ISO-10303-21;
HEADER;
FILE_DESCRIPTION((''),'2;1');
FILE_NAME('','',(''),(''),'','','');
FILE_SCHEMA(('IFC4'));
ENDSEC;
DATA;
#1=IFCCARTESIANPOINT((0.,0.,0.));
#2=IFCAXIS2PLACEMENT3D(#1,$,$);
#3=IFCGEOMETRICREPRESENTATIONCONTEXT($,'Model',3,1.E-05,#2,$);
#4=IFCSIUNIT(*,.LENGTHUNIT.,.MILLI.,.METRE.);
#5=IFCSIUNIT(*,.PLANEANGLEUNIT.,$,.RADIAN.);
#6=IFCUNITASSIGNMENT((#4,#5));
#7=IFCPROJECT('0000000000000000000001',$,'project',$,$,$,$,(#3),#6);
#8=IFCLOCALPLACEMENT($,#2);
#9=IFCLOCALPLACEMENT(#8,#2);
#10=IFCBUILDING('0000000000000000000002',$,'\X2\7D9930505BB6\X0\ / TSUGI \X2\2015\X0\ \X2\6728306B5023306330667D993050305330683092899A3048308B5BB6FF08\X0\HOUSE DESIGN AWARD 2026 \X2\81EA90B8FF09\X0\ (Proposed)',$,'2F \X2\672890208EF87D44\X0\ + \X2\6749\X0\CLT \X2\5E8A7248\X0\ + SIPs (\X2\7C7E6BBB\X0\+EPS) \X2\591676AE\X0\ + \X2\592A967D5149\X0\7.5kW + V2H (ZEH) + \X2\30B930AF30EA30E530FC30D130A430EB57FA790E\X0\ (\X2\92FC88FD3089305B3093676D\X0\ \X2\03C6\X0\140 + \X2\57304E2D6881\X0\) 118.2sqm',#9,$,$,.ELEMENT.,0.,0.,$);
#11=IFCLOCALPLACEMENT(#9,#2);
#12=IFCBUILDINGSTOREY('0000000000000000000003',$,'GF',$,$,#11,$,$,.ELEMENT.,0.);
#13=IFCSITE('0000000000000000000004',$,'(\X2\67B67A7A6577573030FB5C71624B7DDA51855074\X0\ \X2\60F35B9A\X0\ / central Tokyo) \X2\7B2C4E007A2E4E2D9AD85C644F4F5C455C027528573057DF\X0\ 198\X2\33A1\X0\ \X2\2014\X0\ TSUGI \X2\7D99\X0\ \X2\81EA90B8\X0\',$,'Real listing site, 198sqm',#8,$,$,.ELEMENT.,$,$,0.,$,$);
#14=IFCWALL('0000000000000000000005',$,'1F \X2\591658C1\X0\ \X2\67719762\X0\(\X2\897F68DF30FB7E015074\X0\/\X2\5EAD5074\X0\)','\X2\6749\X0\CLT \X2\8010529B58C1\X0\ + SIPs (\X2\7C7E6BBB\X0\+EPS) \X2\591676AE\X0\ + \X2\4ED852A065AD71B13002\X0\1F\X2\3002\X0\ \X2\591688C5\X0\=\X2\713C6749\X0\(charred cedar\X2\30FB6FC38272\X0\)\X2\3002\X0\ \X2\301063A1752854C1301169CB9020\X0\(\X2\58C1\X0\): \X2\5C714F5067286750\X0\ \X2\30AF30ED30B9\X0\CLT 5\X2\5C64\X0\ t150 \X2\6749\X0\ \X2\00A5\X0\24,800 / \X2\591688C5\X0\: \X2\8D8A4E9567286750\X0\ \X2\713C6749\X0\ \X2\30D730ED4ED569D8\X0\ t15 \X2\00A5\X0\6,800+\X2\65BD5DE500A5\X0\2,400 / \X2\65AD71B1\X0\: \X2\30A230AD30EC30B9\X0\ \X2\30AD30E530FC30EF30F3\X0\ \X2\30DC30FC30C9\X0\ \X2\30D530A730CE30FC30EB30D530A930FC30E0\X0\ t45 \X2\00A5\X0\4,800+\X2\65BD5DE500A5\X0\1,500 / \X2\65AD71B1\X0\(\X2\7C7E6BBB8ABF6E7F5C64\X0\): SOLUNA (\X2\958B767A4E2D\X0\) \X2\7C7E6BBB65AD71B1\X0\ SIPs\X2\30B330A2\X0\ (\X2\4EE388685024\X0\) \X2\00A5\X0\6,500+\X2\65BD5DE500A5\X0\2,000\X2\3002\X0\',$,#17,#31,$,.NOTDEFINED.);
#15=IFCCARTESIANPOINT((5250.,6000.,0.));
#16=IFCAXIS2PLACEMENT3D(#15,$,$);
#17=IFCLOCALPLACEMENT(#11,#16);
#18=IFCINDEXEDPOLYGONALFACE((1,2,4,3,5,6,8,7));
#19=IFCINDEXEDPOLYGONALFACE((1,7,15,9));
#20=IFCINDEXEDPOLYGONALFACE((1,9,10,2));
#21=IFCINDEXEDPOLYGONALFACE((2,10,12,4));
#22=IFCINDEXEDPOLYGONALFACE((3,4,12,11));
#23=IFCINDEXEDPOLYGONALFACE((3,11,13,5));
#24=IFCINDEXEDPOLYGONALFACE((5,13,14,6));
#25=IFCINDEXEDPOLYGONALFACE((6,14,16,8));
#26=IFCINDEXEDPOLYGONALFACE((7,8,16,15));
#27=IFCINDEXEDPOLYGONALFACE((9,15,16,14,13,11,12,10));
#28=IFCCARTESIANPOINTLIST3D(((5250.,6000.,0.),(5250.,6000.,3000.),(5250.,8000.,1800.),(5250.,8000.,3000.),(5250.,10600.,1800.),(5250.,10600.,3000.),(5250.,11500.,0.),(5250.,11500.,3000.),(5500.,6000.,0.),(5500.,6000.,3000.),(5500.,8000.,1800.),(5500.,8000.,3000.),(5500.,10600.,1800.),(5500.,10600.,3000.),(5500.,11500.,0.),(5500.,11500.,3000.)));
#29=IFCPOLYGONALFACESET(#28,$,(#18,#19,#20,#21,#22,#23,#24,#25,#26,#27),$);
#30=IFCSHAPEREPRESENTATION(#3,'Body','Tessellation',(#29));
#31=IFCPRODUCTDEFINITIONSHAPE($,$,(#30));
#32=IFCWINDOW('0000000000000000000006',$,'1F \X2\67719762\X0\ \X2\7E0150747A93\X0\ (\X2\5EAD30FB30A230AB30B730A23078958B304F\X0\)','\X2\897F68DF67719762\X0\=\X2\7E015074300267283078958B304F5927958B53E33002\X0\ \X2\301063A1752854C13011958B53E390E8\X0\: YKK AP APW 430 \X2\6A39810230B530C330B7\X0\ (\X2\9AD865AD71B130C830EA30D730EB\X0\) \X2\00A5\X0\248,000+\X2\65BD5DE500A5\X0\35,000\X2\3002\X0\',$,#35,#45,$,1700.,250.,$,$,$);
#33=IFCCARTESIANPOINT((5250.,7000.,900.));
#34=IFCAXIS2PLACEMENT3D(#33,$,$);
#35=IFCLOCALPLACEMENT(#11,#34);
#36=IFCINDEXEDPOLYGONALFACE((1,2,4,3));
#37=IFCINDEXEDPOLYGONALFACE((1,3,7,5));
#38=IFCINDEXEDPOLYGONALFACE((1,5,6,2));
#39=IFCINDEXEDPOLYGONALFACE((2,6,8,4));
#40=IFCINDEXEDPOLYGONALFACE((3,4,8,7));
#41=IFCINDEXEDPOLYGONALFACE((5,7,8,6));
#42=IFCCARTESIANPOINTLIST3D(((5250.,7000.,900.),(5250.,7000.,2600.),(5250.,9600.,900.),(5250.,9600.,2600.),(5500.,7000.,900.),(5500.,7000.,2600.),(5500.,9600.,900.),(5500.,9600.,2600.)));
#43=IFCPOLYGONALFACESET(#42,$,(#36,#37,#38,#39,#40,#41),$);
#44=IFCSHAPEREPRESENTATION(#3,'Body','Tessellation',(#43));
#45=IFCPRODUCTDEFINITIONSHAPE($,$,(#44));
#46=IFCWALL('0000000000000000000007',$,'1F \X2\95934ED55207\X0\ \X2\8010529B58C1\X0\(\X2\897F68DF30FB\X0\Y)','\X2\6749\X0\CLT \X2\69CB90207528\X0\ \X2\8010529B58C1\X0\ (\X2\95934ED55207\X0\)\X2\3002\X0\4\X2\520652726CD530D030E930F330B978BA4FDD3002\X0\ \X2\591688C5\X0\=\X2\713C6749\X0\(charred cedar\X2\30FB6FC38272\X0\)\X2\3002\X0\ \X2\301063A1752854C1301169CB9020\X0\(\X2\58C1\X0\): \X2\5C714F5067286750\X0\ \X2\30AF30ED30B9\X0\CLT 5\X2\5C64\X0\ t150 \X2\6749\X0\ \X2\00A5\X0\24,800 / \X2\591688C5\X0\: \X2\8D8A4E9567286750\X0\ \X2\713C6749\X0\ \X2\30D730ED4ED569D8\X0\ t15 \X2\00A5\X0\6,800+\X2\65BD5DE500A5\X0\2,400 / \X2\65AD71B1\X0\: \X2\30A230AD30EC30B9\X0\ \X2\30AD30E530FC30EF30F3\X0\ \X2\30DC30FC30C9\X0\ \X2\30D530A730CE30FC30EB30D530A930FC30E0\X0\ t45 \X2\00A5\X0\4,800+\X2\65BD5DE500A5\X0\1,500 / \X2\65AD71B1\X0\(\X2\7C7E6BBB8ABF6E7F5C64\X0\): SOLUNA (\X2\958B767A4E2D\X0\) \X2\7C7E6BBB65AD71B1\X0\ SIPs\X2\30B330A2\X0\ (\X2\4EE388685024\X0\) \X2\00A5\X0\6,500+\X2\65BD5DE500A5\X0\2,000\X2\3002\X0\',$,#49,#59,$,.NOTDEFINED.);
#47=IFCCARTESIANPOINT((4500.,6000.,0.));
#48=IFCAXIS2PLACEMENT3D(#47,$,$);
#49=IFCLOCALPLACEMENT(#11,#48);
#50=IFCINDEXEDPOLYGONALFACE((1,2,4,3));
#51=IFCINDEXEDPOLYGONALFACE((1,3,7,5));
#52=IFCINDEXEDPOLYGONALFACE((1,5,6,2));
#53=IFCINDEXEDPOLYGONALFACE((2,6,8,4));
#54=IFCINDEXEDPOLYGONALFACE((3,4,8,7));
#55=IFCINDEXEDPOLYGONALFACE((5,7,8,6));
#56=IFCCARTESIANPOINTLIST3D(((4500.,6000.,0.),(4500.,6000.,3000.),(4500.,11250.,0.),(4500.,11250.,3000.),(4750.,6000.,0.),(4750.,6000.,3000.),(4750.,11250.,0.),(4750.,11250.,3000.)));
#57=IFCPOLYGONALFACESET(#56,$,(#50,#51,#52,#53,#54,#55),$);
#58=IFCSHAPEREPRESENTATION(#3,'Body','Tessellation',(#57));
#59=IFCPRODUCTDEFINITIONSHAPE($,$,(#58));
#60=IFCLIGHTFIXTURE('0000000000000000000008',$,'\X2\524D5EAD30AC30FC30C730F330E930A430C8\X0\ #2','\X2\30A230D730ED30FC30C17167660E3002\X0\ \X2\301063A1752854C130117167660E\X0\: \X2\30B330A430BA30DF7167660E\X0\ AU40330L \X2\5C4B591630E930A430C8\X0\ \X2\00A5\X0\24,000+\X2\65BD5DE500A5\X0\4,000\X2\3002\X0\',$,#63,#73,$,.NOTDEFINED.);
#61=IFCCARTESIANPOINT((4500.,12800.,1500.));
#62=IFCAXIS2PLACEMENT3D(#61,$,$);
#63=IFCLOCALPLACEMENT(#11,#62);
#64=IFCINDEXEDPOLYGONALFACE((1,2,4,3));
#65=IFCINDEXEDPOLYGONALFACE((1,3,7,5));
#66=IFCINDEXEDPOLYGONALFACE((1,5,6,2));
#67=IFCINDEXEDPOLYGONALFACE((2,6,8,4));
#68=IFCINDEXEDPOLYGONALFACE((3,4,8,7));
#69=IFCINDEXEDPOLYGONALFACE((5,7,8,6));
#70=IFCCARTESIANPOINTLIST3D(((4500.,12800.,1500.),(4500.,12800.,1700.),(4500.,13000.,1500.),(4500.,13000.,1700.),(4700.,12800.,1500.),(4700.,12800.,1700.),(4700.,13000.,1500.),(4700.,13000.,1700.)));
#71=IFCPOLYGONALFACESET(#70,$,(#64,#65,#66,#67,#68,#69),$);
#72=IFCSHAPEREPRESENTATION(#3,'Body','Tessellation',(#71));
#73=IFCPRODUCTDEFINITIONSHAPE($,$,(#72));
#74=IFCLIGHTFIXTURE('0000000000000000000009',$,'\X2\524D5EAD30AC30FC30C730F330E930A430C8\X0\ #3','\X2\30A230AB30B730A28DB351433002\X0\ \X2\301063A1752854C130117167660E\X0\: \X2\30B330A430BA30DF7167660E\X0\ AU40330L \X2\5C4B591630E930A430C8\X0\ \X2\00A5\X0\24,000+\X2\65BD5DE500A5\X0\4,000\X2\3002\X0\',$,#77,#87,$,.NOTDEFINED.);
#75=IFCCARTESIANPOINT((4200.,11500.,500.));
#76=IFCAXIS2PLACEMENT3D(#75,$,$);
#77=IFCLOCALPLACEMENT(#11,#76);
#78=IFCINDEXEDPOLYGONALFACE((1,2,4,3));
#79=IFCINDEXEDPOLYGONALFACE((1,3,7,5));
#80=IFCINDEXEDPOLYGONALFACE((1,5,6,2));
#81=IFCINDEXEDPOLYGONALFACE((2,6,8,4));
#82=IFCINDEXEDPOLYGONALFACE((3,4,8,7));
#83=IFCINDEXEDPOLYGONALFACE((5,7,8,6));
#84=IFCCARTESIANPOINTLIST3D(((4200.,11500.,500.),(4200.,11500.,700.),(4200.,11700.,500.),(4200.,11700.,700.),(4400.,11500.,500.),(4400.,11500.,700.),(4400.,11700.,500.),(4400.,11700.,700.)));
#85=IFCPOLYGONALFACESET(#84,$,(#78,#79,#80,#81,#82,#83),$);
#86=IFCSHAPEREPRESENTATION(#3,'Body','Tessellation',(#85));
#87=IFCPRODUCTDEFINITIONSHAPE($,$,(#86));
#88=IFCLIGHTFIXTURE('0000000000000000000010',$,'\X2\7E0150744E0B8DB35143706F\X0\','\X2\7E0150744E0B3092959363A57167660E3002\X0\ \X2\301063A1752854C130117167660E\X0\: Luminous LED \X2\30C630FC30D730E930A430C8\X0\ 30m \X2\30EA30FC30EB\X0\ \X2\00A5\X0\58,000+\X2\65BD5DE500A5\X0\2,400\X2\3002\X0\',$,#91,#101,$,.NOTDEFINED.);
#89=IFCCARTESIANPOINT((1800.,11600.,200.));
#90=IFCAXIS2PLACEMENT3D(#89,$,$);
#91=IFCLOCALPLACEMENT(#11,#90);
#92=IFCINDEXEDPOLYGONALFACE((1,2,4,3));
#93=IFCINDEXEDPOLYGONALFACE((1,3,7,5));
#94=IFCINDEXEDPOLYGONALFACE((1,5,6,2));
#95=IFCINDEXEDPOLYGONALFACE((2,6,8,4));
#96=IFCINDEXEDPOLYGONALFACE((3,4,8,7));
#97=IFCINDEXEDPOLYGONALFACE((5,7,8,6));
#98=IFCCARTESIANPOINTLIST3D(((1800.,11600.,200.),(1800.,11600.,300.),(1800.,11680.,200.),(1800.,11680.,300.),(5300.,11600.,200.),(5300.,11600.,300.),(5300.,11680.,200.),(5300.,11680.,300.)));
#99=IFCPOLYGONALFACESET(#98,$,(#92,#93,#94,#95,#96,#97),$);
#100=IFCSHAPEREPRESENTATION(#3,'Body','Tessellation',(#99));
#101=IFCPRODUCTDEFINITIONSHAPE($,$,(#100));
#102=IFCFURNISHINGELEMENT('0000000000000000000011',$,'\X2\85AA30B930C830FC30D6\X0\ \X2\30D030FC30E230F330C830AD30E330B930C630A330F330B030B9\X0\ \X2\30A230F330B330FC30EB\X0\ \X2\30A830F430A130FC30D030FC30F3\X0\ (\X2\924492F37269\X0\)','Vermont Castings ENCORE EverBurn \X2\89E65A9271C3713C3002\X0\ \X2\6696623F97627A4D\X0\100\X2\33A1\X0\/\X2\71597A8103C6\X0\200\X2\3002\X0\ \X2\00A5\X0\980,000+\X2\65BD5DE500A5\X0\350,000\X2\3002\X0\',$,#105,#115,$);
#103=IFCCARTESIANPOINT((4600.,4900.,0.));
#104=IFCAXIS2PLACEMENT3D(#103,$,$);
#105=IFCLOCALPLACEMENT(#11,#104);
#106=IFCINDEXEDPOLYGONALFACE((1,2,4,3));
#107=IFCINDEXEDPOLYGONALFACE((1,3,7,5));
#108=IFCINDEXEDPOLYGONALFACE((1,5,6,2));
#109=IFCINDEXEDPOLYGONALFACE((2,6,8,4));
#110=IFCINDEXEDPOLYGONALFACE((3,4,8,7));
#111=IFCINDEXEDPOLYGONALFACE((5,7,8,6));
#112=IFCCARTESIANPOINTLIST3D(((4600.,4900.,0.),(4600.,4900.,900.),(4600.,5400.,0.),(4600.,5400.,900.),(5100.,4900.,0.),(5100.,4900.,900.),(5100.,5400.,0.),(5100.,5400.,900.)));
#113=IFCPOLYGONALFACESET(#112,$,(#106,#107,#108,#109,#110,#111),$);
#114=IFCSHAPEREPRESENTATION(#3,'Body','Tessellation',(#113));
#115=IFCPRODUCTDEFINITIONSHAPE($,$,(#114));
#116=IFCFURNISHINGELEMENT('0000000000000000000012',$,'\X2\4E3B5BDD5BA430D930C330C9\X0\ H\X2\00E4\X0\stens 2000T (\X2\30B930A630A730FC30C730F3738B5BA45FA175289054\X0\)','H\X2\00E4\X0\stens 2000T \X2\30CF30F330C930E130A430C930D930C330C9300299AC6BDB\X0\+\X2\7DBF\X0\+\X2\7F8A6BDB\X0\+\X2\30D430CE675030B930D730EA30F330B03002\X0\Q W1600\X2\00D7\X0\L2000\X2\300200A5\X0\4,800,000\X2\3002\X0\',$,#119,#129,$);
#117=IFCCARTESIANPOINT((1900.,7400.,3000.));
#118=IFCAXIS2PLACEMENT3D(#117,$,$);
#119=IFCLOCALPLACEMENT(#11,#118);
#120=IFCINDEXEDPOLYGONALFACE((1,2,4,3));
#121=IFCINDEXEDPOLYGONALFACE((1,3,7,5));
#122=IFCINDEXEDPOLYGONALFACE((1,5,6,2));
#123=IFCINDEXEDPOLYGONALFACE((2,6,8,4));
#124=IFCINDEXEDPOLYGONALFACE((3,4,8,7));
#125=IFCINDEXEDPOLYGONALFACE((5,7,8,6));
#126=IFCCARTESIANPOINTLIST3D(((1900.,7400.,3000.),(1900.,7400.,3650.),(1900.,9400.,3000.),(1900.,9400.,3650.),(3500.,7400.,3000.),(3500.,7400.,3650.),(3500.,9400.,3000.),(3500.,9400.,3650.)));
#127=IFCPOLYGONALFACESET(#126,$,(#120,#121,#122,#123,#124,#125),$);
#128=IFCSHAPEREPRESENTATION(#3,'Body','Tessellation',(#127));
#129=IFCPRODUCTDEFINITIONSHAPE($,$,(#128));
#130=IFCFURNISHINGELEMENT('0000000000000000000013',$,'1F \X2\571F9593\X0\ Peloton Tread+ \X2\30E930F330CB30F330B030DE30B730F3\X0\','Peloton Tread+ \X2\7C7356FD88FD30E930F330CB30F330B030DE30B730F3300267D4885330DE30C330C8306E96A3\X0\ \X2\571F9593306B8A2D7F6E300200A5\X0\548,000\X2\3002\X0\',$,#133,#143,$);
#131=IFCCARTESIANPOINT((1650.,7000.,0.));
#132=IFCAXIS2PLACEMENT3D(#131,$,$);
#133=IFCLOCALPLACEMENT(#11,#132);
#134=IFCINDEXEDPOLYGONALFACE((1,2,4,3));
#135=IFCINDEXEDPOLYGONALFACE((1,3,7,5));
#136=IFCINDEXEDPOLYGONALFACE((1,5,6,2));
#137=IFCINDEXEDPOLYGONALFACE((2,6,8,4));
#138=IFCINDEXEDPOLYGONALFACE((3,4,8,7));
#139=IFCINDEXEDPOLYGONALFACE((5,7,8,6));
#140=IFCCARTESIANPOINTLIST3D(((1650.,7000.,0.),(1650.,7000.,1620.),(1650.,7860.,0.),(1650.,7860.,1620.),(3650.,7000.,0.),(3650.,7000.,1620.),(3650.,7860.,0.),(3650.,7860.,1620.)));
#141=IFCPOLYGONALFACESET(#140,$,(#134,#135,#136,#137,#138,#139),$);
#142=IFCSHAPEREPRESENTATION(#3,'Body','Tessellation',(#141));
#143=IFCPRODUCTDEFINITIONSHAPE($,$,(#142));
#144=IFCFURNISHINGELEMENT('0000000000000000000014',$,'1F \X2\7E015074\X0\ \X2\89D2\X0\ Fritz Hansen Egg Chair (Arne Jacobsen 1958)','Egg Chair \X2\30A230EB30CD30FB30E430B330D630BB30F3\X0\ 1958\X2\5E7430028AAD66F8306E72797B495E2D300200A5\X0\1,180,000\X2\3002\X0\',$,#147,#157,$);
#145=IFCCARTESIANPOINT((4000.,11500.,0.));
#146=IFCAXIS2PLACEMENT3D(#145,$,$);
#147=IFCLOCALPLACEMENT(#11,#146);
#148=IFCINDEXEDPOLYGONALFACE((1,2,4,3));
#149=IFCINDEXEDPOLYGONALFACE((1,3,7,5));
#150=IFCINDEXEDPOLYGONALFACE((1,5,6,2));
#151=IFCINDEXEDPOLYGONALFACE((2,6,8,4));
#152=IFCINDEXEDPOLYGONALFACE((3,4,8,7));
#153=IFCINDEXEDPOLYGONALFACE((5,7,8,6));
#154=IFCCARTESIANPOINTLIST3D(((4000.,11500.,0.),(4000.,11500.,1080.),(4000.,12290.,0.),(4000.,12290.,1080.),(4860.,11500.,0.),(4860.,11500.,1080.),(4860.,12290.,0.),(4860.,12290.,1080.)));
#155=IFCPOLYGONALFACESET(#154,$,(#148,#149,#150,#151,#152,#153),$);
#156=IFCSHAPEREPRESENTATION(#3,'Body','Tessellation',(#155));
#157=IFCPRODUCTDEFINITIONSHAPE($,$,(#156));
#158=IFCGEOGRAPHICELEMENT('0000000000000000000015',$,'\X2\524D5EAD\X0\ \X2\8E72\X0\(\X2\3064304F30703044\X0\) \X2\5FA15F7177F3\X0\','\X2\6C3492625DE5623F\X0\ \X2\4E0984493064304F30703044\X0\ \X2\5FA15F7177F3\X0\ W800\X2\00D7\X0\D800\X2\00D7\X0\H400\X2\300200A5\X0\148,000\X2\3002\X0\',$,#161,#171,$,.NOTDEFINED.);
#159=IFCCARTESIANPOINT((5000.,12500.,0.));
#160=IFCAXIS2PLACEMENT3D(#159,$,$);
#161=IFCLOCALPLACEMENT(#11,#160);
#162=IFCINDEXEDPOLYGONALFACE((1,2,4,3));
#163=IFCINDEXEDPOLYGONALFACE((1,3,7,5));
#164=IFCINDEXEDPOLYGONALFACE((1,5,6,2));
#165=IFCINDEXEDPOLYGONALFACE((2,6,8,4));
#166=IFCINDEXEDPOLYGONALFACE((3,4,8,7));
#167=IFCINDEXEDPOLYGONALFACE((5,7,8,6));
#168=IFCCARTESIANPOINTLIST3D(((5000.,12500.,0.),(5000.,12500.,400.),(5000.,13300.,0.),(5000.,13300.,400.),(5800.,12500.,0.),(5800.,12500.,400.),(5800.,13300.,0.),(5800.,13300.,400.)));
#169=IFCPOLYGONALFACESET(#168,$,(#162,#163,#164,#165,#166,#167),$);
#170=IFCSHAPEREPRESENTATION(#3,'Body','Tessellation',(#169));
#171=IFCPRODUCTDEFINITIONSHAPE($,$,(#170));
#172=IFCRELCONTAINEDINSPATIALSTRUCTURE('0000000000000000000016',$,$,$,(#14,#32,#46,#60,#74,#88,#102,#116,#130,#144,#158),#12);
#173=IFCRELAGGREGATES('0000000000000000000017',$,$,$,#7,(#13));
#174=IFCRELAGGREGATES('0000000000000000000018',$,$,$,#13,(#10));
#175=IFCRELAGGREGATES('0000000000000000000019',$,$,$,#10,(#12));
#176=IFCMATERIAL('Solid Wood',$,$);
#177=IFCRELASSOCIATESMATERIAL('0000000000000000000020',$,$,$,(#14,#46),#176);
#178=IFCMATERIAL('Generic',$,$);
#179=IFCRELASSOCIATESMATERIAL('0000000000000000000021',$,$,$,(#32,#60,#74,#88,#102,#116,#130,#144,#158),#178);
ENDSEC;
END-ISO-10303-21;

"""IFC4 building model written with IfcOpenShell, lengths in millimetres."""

from ifc_helpers import new_model, si_unit, frame, frame_2d, origin, place, context, project, spatial, rectangle, extrude, material, element, fill, save


model = new_model("IFC4")

# Units and contexts
model_context = context("Model", 3, precision=1e-05, world=origin())
ifc_project = project(units=[si_unit("LENGTHUNIT", "METRE", prefix="MILLI"), si_unit("PLANEANGLEUNIT", "RADIAN")], contexts=[model_context])

# Site, building, storey
site_placement = place(None, origin())
site = spatial("IfcSite", under=ifc_project, at=site_placement, Name="(架空敷地・山手線内側 想定 / central Tokyo) 第一種中高層住居専用地域 198㎡ — TSUGI 継 自邸", ObjectType="Real listing site, 198sqm", CompositionType="ELEMENT", RefElevation=0.0)
building_placement = place(site_placement, origin())
building = spatial("IfcBuilding", under=site, at=building_placement, Name="継ぐ家 / TSUGI ― 木に倣って継ぐことを覚える家（HOUSE DESIGN AWARD 2026 自邸） (Proposed)", ObjectType="2F 木造軸組 + 杉CLT 床版 + SIPs (籾殻+EPS) 外皮 + 太陽光7.5kW + V2H (ZEH) + スクリューパイル基礎 (鋼製らせん杭 φ140 + 地中梁) 118.2sqm", CompositionType="ELEMENT", ElevationOfRefHeight=0.0, ElevationOfTerrain=0.0)
storey_placement = place(building_placement, origin())
storey = spatial("IfcBuildingStorey", under=building, at=storey_placement, Name="GF", CompositionType="ELEMENT", Elevation=0.0)

# Shared definitions
ifc_material_1 = material(Name="Generic")

# Wall, opening, window
ifc_material_2 = material(Name="Solid Wood")
wall_1_placement = place(storey_placement, frame((5250.0, 6000.0, 0.0)))
wall_1 = element("IfcWall", 1, at=wall_1_placement, inside=storey, material=ifc_material_2, Name="1F 外壁 東面(西棟・縁側/庭側)", Description="杉CLT 耐力壁 + SIPs (籾殻+EPS) 外皮 + 付加断熱。1F。 外装=焼杉(charred cedar・濃色)。 【採用品】構造(壁): 山佐木材 クロスCLT 5層 t150 杉 ¥24,800 / 外装: 越井木材 焼杉 プロ仕様 t15 ¥6,800+施工¥2,400 / 断熱: アキレス キューワン ボード フェノールフォーム t45 ¥4,800+施工¥1,500 / 断熱(籾殻調湿層): SOLUNA (開発中) 籾殻断熱 SIPsコア (代表値) ¥6,500+施工¥2,000。", PredefinedType="NOTDEFINED", context=model_context, shape_type="SweptSolid", body=[
    extrude(rectangle(XDim=250.0, YDim=5500.0, at=frame_2d((125.0, 2750.0))), frame((5250.0, 6000.0, 0.0)), (0.0, 0.0, 1.0), 3000.0),
])
opening_placement = place(storey_placement, frame((5250.0, 7000.0, 900.0)))
opening = element("IfcOpeningElement", 2, at=opening_placement, cuts=wall_1, PredefinedType="NOTDEFINED", context=model_context, shape_type="SweptSolid", body=[
    extrude(rectangle(XDim=250.0, YDim=2600.0, at=frame_2d((125.0, 1300.0))), frame((5250.0, 7000.0, 900.0)), (0.0, 0.0, 1.0), 1700.0),
])
window_placement = place(storey_placement, frame((5250.0, 7000.0, 900.0)))
window = element("IfcWindow", 3, at=window_placement, inside=storey, material=ifc_material_1, Name="1F 東面 縁側窓 (庭・アカシアへ開く)", Description="西棟東面=縁側。木へ開く大開口。 【採用品】開口部: YKK AP APW 430 樹脂サッシ (高断熱トリプル) ¥248,000+施工¥35,000。", OverallHeight=1700.0, OverallWidth=250.0, context=model_context, shape_type="SweptSolid", body=[
    extrude(rectangle(XDim=250.0, YDim=2600.0, at=frame_2d((125.0, 1300.0))), frame((5250.0, 7000.0, 900.0)), (0.0, 0.0, 1.0), 1700.0),
])
fill(opening, window)

# Wall
wall_2_placement = place(storey_placement, frame((4500.0, 6000.0, 0.0)))
element("IfcWall", 4, at=wall_2_placement, inside=storey, material=ifc_material_2, Name="1F 間仕切 耐力壁(西棟・Y)", Description="杉CLT 構造用 耐力壁 (間仕切)。4分割法バランス確保。 外装=焼杉(charred cedar・濃色)。 【採用品】構造(壁): 山佐木材 クロスCLT 5層 t150 杉 ¥24,800 / 外装: 越井木材 焼杉 プロ仕様 t15 ¥6,800+施工¥2,400 / 断熱: アキレス キューワン ボード フェノールフォーム t45 ¥4,800+施工¥1,500 / 断熱(籾殻調湿層): SOLUNA (開発中) 籾殻断熱 SIPsコア (代表値) ¥6,500+施工¥2,000。", PredefinedType="NOTDEFINED", context=model_context, shape_type="SweptSolid", body=[
    extrude(rectangle(XDim=250.0, YDim=5250.0, at=frame_2d((125.0, 2625.0))), frame((4500.0, 6000.0, 0.0)), (0.0, 0.0, 1.0), 3000.0),
])

# Light fixtures
light_fixture_1_placement = place(storey_placement, frame((4500.0, 12800.0, 1500.0)))
element("IfcLightFixture", 5, at=light_fixture_1_placement, inside=storey, material=ifc_material_1, Name="前庭ガーデンライト #2", Description="アプローチ照明。 【採用品】照明: コイズミ照明 AU40330L 屋外ライト ¥24,000+施工¥4,000。", PredefinedType="NOTDEFINED", context=model_context, shape_type="SweptSolid", body=[
    extrude(rectangle(XDim=200.0, YDim=200.0, at=frame_2d((100.0, 100.0))), frame((4500.0, 12800.0, 1500.0)), (0.0, 0.0, 1.0), 200.0),
])
light_fixture_2_placement = place(storey_placement, frame((4200.0, 11500.0, 500.0)))
element("IfcLightFixture", 6, at=light_fixture_2_placement, inside=storey, material=ifc_material_1, Name="前庭ガーデンライト #3", Description="アカシア足元。 【採用品】照明: コイズミ照明 AU40330L 屋外ライト ¥24,000+施工¥4,000。", PredefinedType="NOTDEFINED", context=model_context, shape_type="SweptSolid", body=[
    extrude(rectangle(XDim=200.0, YDim=200.0, at=frame_2d((100.0, 100.0))), frame((4200.0, 11500.0, 500.0)), (0.0, 0.0, 1.0), 200.0),
])
light_fixture_3_placement = place(storey_placement, frame((1800.0, 11600.0, 200.0)))
element("IfcLightFixture", 7, at=light_fixture_3_placement, inside=storey, material=ifc_material_1, Name="縁側下足元灯", Description="縁側下を間接照明。 【採用品】照明: Luminous LED テープライト 30m リール ¥58,000+施工¥2,400。", PredefinedType="NOTDEFINED", context=model_context, shape_type="SweptSolid", body=[
    extrude(rectangle(XDim=3500.0, YDim=80.0, at=frame_2d((1750.0, 40.0))), frame((1800.0, 11600.0, 200.0)), (0.0, 0.0, 1.0), 100.0),
])

# Furnishing elements
furnishing_1_placement = place(storey_placement, frame((4600.0, 4900.0, 0.0)))
element("IfcFurnishingElement", 8, at=furnishing_1_placement, inside=storey, material=ifc_material_1, Name="薪ストーブ バーモントキャスティングス アンコール エヴァーバーン (鉄鋳物)", Description="Vermont Castings ENCORE EverBurn 触媒燃焼。 暖房面積100㎡/煙突φ200。 ¥980,000+施工¥350,000。", context=model_context, shape_type="SweptSolid", body=[
    extrude(rectangle(XDim=500.0, YDim=500.0, at=frame_2d((250.0, 250.0))), frame((4600.0, 4900.0, 0.0)), (0.0, 0.0, 1.0), 900.0),
])
furnishing_2_placement = place(storey_placement, frame((1900.0, 7400.0, 3000.0)))
element("IfcFurnishingElement", 9, at=furnishing_2_placement, inside=storey, material=ifc_material_1, Name="主寝室ベッド Hästens 2000T (スウェーデン王室御用達)", Description="Hästens 2000T ハンドメイドベッド。馬毛+綿+羊毛+ピノ材スプリング。Q W1600×L2000。¥4,800,000。", context=model_context, shape_type="SweptSolid", body=[
    extrude(rectangle(XDim=1600.0, YDim=2000.0, at=frame_2d((800.0, 1000.0))), frame((1900.0, 7400.0, 3000.0)), (0.0, 0.0, 1.0), 650.0),
])
furnishing_3_placement = place(storey_placement, frame((1650.0, 7000.0, 0.0)))
element("IfcFurnishingElement", 10, at=furnishing_3_placement, inside=storey, material=ifc_material_1, Name="1F 土間 Peloton Tread+ ランニングマシン", Description="Peloton Tread+ 米国製ランニングマシン。柔術マットの隣 土間に設置。¥548,000。", context=model_context, shape_type="SweptSolid", body=[
    extrude(rectangle(XDim=2000.0, YDim=860.0, at=frame_2d((1000.0, 430.0))), frame((1650.0, 7000.0, 0.0)), (0.0, 0.0, 1.0), 1620.0),
])
furnishing_4_placement = place(storey_placement, frame((4000.0, 11500.0, 0.0)))
element("IfcFurnishingElement", 11, at=furnishing_4_placement, inside=storey, material=ifc_material_1, Name="1F 縁側 角 Fritz Hansen Egg Chair (Arne Jacobsen 1958)", Description="Egg Chair アルネ・ヤコブセン 1958年。読書の特等席。¥1,180,000。", context=model_context, shape_type="SweptSolid", body=[
    extrude(rectangle(XDim=860.0, YDim=790.0, at=frame_2d((430.0, 395.0))), frame((4000.0, 11500.0, 0.0)), (0.0, 0.0, 1.0), 1080.0),
])

# Geographic element
geographic_element_1_placement = place(storey_placement, frame((5000.0, 12500.0, 0.0)))
element("IfcGeographicElement", 12, at=geographic_element_1_placement, inside=storey, material=ifc_material_1, Name="前庭 蹲(つくばい) 御影石", Description="水鉢工房 三葉つくばい 御影石 W800×D800×H400。¥148,000。", PredefinedType="NOTDEFINED", context=model_context, shape_type="SweptSolid", body=[
    extrude(rectangle(XDim=800.0, YDim=800.0, at=frame_2d((400.0, 400.0))), frame((5000.0, 12500.0, 0.0)), (0.0, 0.0, 1.0), 400.0),
])

save(model, "model.ifc")
